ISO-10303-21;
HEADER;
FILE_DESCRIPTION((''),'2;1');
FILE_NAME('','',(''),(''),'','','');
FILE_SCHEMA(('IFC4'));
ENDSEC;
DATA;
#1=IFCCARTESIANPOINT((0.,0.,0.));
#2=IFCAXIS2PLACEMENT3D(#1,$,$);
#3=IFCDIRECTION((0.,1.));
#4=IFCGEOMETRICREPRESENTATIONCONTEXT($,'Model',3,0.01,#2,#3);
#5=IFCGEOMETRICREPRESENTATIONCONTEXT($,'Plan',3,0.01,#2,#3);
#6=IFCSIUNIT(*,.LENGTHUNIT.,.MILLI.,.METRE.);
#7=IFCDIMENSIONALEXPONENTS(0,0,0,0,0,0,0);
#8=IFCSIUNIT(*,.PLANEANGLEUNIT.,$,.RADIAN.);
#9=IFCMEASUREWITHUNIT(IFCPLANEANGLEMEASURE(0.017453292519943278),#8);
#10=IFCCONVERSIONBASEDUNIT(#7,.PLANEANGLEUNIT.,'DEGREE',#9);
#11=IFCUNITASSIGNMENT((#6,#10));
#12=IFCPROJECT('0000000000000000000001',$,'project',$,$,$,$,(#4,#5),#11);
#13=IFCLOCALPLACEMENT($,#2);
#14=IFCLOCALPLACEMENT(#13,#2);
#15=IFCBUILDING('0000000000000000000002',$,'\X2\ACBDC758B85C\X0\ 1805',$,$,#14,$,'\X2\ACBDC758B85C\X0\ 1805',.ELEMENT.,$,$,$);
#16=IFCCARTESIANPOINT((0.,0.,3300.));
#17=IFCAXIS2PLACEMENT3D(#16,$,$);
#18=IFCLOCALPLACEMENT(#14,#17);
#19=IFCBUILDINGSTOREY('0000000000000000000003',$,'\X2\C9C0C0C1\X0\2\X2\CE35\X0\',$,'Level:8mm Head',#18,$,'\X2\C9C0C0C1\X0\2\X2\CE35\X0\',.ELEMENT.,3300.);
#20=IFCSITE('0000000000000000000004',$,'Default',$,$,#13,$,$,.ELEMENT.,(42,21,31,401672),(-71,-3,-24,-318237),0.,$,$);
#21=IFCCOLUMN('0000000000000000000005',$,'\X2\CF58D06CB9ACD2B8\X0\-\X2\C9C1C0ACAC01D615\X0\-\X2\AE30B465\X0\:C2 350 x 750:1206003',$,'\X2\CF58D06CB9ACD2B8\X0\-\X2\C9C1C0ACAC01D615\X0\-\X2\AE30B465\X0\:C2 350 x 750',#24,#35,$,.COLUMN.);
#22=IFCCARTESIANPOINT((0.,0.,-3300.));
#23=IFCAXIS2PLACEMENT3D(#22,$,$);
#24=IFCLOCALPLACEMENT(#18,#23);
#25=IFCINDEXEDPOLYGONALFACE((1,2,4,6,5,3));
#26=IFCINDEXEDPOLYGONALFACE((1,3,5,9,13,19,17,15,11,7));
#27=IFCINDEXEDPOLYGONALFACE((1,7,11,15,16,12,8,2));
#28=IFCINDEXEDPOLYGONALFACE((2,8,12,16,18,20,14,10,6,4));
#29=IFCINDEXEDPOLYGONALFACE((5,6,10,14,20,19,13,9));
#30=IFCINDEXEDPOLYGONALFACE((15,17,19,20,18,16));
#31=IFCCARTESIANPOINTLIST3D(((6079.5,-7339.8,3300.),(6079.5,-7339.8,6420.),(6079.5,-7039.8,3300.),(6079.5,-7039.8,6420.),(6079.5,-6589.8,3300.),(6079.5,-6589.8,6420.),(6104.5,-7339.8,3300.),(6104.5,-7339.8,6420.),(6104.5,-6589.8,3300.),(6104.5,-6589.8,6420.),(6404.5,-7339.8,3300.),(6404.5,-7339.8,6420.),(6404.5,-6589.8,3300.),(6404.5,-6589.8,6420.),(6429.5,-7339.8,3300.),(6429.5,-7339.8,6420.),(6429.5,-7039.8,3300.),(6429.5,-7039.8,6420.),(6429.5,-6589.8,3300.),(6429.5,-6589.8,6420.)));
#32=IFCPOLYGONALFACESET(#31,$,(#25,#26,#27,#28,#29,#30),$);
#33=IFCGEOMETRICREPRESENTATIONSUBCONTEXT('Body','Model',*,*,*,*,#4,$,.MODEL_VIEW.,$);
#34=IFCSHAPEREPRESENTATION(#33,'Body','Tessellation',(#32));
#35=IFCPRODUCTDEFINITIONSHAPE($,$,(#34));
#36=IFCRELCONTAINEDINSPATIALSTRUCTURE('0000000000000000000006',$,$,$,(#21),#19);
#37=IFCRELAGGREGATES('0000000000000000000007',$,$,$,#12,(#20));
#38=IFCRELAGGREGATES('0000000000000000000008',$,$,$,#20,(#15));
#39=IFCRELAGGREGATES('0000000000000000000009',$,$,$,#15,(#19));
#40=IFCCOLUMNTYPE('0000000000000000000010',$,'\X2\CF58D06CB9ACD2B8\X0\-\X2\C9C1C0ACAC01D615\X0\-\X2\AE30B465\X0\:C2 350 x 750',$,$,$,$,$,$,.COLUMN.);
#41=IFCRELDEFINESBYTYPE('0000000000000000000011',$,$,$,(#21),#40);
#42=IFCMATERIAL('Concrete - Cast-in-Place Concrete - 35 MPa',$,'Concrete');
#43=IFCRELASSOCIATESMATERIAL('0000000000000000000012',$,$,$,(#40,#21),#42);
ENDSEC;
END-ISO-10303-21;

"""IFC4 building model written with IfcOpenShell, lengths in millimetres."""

from ifc_helpers import new_model, entity, si_unit, converted_unit, direction, frame, origin, place, context, subcontext, project, spatial, indexed_curve, outline, extrude, source, transform, mapped, material, type_object, type_shapes, element, save


model = new_model("IFC4")

# Units and contexts
model_context = context("Model", 3, precision=0.01, world=origin(), true_north=direction((0.0, 1.0)))
plan_context = context("Plan", 3, precision=0.01, world=origin(), true_north=direction((0.0, 1.0)))
body_context = subcontext(model_context, "Body", "Model", "MODEL_VIEW")
ifc_project = project(units=[si_unit("LENGTHUNIT", "METRE", prefix="MILLI"), converted_unit("PLANEANGLEUNIT", "DEGREE", entity("IfcPlaneAngleMeasure", 0.017453292519943278), si_unit("PLANEANGLEUNIT", "RADIAN"), dimensions=[0, 0, 0, 0, 0, 0, 0])], contexts=[model_context, plan_context])

# Site, building, storey
site_placement = place(None, origin())
site = spatial("IfcSite", under=ifc_project, at=site_placement, Name="Default", CompositionType="ELEMENT", RefLatitude=(42, 21, 31, 401672), RefLongitude=(-71, -3, -24, -318237), RefElevation=0.0)
building_placement = place(site_placement, origin())
building = spatial("IfcBuilding", under=site, at=building_placement, Name="경의로 1805", LongName="경의로 1805", CompositionType="ELEMENT")
storey_placement = place(building_placement, frame((0.0, 0.0, 3300.0)))
storey = spatial("IfcBuildingStorey", under=building, at=storey_placement, Name="지상2층", ObjectType="Level:8mm Head", LongName="지상2층", CompositionType="ELEMENT", Elevation=3300.0)

# Column
ifc_material_1 = material(Name="Concrete - Cast-in-Place Concrete - 35 MPa", Category="Concrete")
column_type_1 = type_object("IfcColumnType", Name="콘크리트-직사각형-기둥:C2 350 x 750", PredefinedType="COLUMN", material=ifc_material_1)
shared_shape_1 = source(origin(), body_context, "Body", "SweptSolid", [
    extrude(outline(indexed_curve([(-175.0, -390.0), (-150.0, -390.0), (150.0, -390.0), (175.0, -390.0), (175.0, 60.0), (175.0, 360.0), (150.0, 360.0), (-150.0, 360.0), (-175.0, 360.0), (-175.0, 60.0), (-175.0, -390.0)], self_intersect=False)), frame((6254.5, -6979.8, 3300.0), z_axis=(0.0, 0.0, 1.0), x_axis=(-1.0, 0.0, 0.0)), (0.0, 0.0, 1.0), 3120.0),
])
type_shapes(column_type_1, [shared_shape_1])
column_1_placement = place(storey_placement, frame((0.0, 0.0, -3300.0)))
element("IfcColumn", 1, at=column_1_placement, inside=storey, type_object=column_type_1, material=ifc_material_1, Name="콘크리트-직사각형-기둥:C2 350 x 750:1206003", ObjectType="콘크리트-직사각형-기둥:C2 350 x 750", PredefinedType="COLUMN", context=body_context, shape_type="MappedRepresentation", body=[
    mapped(shared_shape_1, transform((0.0, 0.0, 0.0), scale=1.0)),
])

save(model, "model.ifc")
